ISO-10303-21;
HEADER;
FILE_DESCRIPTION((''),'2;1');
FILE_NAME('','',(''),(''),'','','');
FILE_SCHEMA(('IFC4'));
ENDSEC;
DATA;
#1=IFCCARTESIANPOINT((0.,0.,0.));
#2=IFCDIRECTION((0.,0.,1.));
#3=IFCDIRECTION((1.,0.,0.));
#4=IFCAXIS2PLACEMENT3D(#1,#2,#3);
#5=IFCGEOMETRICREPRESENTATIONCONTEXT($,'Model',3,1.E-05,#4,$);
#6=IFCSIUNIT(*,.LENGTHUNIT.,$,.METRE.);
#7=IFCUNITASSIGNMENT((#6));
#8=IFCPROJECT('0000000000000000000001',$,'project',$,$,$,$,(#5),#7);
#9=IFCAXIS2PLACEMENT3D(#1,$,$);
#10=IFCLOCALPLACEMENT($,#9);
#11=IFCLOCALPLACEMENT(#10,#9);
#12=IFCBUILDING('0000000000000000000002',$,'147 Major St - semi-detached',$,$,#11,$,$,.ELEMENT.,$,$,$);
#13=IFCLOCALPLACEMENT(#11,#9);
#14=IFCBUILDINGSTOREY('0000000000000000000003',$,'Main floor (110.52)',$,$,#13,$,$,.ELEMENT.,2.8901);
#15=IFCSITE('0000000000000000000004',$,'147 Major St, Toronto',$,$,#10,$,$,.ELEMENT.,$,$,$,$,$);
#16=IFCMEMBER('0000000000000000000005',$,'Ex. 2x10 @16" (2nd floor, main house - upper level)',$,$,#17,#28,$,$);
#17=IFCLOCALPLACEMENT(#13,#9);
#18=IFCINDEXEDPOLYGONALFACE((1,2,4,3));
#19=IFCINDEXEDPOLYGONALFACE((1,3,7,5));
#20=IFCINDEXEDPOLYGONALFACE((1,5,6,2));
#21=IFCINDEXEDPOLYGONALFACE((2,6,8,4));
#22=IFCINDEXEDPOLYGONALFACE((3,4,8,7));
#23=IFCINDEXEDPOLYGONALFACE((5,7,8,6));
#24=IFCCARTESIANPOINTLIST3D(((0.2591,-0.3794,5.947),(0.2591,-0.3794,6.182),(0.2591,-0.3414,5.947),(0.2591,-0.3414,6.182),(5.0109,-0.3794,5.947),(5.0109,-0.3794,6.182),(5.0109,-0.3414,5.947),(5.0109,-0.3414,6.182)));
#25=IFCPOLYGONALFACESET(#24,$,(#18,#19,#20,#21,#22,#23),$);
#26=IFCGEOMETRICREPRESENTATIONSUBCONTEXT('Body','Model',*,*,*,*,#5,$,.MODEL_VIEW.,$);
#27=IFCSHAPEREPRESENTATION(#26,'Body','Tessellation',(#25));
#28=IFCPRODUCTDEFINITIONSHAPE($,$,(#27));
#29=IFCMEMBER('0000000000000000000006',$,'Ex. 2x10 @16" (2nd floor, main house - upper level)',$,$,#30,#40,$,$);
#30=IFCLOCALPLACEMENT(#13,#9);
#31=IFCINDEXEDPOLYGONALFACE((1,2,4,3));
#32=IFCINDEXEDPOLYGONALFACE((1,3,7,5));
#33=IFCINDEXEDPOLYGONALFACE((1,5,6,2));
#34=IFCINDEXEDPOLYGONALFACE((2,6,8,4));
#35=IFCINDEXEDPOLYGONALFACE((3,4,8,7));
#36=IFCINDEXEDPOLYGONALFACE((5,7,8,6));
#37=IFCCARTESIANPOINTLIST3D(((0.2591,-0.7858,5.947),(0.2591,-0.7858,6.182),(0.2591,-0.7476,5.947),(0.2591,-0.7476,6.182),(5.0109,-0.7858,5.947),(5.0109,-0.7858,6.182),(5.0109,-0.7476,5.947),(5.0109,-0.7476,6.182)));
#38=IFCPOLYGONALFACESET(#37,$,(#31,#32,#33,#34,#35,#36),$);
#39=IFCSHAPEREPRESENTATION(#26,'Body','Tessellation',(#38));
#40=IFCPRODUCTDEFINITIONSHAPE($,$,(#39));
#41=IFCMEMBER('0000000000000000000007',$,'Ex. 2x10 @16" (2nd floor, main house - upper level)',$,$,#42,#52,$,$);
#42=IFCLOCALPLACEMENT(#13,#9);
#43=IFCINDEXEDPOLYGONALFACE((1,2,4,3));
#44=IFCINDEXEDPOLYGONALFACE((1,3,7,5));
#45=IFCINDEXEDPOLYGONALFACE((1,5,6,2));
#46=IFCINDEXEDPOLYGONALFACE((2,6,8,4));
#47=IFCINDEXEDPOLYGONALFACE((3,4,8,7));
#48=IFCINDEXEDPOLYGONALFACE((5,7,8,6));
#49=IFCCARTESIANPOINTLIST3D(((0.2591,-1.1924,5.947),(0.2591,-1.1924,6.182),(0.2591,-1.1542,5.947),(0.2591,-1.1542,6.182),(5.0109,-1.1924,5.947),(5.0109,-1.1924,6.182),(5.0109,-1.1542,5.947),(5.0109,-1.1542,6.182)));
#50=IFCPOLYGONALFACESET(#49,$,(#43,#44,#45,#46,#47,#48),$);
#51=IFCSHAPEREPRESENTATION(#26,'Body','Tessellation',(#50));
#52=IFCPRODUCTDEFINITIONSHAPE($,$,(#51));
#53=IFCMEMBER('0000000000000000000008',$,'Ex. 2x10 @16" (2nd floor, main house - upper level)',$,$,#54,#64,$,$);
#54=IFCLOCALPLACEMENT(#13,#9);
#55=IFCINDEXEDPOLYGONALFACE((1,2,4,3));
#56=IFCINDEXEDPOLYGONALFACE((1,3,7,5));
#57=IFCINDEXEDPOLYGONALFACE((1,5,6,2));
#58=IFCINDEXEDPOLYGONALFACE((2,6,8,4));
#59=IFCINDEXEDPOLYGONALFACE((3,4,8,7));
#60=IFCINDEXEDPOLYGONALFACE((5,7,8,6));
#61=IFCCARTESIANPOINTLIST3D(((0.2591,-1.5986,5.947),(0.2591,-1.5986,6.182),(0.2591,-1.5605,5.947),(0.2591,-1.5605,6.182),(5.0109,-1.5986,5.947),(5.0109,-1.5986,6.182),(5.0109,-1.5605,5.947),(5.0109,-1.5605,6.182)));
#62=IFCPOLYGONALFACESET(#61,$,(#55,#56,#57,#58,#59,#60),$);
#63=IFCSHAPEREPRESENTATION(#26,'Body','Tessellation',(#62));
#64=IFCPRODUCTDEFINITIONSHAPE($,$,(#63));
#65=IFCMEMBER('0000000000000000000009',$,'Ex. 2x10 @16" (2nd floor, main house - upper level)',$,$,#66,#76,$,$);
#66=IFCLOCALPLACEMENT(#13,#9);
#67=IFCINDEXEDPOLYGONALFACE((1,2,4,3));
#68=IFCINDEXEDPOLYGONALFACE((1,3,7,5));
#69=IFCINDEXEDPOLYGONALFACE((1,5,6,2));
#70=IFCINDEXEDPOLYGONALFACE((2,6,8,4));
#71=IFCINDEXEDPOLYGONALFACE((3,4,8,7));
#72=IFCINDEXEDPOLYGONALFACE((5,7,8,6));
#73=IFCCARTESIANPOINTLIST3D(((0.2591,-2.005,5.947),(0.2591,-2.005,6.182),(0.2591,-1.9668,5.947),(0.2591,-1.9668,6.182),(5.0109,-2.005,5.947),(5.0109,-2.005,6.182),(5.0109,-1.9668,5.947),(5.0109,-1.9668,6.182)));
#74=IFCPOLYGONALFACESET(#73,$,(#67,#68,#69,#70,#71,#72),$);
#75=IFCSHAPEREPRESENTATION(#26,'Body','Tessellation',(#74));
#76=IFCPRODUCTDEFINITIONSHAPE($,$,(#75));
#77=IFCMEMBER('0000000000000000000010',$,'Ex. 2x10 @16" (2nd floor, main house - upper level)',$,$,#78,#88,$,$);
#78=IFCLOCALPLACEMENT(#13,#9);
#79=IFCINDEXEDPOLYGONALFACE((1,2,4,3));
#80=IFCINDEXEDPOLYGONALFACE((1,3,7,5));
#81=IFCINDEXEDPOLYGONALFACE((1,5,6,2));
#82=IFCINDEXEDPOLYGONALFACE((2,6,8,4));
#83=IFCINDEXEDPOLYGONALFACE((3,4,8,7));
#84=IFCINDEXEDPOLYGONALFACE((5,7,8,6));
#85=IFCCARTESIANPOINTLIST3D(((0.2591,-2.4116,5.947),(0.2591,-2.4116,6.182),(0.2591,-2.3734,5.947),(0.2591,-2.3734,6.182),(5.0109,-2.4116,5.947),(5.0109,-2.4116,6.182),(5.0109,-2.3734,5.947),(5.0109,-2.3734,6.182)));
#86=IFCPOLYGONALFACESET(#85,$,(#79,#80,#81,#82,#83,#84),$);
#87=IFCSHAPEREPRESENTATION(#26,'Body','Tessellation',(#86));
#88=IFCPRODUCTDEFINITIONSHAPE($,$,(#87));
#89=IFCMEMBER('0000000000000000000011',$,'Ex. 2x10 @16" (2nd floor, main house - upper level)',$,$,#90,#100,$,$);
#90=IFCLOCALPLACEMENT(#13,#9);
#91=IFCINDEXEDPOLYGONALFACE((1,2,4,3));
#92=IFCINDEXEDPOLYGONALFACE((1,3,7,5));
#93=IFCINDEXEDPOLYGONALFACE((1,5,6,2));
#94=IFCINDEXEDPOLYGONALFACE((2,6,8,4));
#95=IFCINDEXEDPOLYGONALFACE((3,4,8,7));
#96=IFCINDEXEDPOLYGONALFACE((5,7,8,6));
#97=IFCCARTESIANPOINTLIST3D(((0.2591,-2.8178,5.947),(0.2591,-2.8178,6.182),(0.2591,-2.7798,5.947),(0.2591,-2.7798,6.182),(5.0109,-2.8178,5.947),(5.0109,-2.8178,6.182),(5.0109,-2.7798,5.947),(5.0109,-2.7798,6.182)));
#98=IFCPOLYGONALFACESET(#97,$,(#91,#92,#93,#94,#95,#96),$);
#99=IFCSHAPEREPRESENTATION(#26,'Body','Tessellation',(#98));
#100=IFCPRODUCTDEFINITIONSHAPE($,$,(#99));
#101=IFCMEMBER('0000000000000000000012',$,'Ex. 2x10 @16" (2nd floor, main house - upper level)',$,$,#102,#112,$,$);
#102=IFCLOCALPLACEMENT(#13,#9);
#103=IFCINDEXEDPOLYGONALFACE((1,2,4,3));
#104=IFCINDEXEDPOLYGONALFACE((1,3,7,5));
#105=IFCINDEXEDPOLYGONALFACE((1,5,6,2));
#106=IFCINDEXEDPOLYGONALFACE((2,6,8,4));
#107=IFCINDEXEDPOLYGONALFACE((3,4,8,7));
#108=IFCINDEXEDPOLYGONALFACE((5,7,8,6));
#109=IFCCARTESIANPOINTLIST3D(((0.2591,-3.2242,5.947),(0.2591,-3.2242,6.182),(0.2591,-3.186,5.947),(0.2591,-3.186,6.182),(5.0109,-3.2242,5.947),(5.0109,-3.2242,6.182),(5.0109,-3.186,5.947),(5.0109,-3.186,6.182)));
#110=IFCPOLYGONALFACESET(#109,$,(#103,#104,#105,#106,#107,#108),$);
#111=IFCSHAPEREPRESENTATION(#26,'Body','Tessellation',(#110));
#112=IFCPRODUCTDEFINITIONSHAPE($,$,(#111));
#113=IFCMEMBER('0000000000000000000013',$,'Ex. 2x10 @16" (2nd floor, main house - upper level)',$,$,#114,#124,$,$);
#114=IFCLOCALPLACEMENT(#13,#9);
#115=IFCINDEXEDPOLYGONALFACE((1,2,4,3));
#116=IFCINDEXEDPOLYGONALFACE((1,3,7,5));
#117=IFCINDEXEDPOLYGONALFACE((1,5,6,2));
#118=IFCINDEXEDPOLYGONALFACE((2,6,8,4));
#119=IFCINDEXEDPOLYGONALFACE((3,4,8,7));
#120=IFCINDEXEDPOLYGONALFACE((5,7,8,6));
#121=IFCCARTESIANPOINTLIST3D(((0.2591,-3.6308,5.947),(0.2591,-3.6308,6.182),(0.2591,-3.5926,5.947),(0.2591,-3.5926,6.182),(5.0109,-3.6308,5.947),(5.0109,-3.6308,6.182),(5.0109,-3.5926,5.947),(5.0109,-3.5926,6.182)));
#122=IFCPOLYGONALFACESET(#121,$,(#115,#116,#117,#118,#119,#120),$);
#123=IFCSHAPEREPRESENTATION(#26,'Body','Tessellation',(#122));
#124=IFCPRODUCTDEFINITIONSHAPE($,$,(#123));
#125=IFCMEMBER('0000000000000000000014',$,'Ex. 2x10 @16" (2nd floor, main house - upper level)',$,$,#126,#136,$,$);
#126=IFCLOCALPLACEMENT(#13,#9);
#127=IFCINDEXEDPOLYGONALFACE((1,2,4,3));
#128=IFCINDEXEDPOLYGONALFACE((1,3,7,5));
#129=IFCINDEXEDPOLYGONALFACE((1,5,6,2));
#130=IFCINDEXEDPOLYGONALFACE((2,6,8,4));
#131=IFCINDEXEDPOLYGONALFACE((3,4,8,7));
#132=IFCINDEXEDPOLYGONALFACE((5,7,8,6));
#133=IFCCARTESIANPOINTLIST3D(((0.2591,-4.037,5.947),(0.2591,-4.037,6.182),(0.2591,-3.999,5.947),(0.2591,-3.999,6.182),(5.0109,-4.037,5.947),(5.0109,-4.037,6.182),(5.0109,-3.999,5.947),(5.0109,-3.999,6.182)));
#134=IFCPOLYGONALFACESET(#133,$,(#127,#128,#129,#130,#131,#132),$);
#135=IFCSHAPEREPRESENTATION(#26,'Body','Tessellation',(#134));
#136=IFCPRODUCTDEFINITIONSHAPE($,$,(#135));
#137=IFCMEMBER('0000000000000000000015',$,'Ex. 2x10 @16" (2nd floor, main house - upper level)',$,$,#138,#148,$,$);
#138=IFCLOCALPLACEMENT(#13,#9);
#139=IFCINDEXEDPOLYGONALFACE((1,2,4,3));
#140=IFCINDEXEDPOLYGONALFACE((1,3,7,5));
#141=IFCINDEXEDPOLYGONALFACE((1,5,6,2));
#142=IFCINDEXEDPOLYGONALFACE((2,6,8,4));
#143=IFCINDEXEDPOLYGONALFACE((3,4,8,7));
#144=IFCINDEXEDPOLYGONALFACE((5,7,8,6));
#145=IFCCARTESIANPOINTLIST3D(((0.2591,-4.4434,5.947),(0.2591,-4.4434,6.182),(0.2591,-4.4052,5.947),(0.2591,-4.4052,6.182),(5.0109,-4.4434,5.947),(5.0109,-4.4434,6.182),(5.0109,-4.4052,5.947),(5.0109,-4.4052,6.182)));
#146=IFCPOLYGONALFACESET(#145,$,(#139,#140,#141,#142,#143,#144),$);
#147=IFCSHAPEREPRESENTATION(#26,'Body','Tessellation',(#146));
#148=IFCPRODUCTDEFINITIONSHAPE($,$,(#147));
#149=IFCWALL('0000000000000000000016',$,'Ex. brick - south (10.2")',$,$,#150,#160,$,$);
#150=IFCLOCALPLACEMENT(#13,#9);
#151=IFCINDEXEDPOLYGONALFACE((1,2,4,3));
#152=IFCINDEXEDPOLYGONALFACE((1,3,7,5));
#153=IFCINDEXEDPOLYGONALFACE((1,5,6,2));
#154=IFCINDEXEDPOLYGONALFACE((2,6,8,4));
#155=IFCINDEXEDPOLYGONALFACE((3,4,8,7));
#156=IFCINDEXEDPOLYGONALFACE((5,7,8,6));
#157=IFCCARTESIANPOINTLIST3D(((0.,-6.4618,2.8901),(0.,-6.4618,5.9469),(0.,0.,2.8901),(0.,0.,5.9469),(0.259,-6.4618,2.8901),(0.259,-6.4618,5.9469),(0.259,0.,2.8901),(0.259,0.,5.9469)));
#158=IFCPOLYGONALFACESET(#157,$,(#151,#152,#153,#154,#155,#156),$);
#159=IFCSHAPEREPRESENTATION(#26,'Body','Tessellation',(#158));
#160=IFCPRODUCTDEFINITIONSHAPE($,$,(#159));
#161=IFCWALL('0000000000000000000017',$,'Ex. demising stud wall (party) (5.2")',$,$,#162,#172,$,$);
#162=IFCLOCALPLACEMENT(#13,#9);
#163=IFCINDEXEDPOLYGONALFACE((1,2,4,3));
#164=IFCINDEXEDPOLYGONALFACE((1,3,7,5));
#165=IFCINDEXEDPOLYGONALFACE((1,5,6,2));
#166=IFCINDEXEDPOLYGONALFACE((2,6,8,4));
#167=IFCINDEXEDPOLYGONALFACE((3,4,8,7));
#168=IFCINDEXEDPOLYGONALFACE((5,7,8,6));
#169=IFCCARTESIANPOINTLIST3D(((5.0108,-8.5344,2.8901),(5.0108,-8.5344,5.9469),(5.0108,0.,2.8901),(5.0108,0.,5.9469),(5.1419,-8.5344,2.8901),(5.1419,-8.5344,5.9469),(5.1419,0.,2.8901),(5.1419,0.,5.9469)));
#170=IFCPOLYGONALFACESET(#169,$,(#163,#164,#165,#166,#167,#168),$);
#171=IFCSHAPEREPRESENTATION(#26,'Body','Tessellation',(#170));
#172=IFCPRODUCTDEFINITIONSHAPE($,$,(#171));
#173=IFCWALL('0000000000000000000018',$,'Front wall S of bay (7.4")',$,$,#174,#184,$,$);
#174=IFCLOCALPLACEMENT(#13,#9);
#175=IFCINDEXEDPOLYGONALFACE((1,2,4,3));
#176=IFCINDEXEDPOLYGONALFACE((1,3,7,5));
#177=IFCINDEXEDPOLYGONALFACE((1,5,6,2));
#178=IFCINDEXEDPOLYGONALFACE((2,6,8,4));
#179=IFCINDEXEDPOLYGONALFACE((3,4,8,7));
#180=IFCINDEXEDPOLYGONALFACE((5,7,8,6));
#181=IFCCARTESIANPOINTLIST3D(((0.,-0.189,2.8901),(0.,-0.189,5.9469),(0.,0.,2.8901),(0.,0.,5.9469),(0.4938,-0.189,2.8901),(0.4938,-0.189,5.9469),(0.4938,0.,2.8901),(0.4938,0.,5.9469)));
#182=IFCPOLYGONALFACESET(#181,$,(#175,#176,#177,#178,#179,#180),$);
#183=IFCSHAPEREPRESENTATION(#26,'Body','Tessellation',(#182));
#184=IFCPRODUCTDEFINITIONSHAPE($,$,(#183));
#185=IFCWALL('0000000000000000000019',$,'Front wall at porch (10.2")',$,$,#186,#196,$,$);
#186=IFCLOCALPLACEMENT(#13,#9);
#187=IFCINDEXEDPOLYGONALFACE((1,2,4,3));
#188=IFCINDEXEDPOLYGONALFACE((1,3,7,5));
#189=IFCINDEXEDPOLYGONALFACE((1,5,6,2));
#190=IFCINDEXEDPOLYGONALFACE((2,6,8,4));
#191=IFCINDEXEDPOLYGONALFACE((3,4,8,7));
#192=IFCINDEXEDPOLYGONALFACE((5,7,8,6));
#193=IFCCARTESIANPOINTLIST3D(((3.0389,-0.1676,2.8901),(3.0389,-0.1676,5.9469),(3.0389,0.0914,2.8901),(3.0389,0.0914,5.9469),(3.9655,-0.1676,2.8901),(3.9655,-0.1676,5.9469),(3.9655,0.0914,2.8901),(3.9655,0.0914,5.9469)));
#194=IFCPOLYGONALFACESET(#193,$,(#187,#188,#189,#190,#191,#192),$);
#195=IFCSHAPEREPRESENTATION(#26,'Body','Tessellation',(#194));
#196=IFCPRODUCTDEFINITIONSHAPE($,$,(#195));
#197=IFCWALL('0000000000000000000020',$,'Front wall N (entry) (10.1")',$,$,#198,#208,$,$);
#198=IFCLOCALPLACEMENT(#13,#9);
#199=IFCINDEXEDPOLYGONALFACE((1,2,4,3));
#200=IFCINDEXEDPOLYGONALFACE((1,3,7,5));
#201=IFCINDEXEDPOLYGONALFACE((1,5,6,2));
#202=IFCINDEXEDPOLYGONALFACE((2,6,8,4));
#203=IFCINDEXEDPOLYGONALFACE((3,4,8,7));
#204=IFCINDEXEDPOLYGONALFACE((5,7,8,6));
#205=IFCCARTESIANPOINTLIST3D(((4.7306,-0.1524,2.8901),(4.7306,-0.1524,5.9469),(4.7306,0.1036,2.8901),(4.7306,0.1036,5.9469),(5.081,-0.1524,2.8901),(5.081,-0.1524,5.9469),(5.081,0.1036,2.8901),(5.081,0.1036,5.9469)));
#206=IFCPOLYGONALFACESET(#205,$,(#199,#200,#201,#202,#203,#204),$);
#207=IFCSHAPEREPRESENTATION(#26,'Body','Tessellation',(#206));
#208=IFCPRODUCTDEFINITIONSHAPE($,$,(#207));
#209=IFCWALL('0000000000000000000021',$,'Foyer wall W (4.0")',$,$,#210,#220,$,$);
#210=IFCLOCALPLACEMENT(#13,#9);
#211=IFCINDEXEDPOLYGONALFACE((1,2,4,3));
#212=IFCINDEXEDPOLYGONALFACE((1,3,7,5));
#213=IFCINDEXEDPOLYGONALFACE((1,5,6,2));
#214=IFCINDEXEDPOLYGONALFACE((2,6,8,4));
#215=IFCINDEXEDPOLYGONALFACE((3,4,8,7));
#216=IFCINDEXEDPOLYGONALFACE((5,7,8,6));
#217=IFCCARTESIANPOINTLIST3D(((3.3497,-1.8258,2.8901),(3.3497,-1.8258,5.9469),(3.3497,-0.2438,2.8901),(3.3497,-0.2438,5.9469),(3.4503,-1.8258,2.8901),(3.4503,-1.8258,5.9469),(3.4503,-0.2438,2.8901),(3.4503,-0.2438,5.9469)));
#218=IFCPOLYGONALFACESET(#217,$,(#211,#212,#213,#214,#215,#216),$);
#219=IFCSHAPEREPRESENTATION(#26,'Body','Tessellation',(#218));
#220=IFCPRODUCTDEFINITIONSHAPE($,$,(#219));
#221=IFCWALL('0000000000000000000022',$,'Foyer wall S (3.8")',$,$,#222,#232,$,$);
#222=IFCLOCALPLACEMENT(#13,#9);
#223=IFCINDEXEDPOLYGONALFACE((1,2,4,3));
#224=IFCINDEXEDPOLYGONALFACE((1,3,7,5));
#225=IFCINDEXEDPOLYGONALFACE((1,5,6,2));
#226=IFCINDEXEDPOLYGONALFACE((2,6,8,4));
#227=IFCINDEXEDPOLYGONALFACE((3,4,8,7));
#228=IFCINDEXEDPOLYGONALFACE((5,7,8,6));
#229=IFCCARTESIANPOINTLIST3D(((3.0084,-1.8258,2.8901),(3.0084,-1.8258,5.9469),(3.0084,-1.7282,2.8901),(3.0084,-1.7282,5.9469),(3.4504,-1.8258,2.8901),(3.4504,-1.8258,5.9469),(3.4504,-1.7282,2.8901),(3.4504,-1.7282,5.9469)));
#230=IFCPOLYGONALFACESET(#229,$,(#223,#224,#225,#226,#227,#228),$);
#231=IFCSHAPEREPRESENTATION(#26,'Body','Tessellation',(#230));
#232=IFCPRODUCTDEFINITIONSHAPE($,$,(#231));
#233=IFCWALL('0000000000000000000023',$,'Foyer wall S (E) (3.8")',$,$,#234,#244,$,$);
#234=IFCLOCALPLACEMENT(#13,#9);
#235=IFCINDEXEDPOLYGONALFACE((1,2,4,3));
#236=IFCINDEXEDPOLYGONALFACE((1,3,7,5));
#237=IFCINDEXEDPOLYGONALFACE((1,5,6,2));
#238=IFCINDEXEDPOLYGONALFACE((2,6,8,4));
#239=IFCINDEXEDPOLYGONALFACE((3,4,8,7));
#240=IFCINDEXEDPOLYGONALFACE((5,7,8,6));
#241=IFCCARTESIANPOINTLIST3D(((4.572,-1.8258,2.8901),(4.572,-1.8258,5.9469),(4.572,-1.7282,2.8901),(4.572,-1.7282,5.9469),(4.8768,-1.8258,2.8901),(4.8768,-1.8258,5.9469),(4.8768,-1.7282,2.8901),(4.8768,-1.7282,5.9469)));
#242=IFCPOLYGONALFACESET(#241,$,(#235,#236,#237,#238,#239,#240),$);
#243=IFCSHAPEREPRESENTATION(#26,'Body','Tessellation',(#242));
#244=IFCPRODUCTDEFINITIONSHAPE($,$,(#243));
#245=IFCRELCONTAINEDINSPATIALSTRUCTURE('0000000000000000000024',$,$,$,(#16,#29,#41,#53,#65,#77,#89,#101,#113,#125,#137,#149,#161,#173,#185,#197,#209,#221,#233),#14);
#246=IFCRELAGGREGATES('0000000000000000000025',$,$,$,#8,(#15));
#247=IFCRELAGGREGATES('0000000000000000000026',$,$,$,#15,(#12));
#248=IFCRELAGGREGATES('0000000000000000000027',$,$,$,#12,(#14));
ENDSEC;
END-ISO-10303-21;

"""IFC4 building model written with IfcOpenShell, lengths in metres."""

from ifc_helpers import new_model, si_unit, frame, origin, origin_with_axes, place, context, subcontext, project, spatial, rectangle, extrude, element, save


model = new_model("IFC4")

# Units and contexts
model_context = context("Model", 3, precision=1e-05, world=origin_with_axes())
body_context = subcontext(model_context, "Body", "Model", "MODEL_VIEW")
ifc_project = project(units=[si_unit("LENGTHUNIT", "METRE")], contexts=[model_context])

# Site, building, storey
site_placement = place(None, origin())
site = spatial("IfcSite", under=ifc_project, at=site_placement, Name="147 Major St, Toronto", CompositionType="ELEMENT")
building_placement = place(site_placement, origin())
building = spatial("IfcBuilding", under=site, at=building_placement, Name="147 Major St - semi-detached", CompositionType="ELEMENT")
storey_placement = place(building_placement, origin())
storey = spatial("IfcBuildingStorey", under=building, at=storey_placement, Name="Main floor (110.52)", CompositionType="ELEMENT", Elevation=2.8901)

# Members
for number, where, name in (
    (1, (2.635, -0.3604, 5.947), "Ex. 2x10 @16\" (2nd floor, main house - upper level)"),
    (2, (2.635, -0.7667, 5.947), "Ex. 2x10 @16\" (2nd floor, main house - upper level)"),
    (3, (2.635, -1.1733, 5.947), "Ex. 2x10 @16\" (2nd floor, main house - upper level)"),
    (4, (2.635, -1.5796, 5.947), "Ex. 2x10 @16\" (2nd floor, main house - upper level)"),
    (5, (2.635, -1.9859, 5.947), "Ex. 2x10 @16\" (2nd floor, main house - upper level)"),
    (6, (2.635, -2.3925, 5.947), "Ex. 2x10 @16\" (2nd floor, main house - upper level)"),
    (7, (2.635, -2.7988, 5.947), "Ex. 2x10 @16\" (2nd floor, main house - upper level)"),
    (8, (2.635, -3.2051, 5.947), "Ex. 2x10 @16\" (2nd floor, main house - upper level)"),
    (9, (2.635, -3.6117, 5.947), "Ex. 2x10 @16\" (2nd floor, main house - upper level)"),
    (10, (2.635, -4.018, 5.947), "Ex. 2x10 @16\" (2nd floor, main house - upper level)"),
    (11, (2.635, -4.4243, 5.947), "Ex. 2x10 @16\" (2nd floor, main house - upper level)"),
):
    element("IfcMember", number, at=place(storey_placement, frame(where)), inside=storey, Name=name, context=body_context, shape_type="SweptSolid", body=[
        extrude(rectangle(XDim=4.7518, YDim=0.0381), origin_with_axes(), (0.0, 0.0, 1.0), 0.235),
    ])

# Walls
wall_1_placement = place(storey_placement, frame((0.1295, -3.2309, 2.8901)))
element("IfcWall", 12, at=wall_1_placement, inside=storey, Name="Ex. brick - south (10.2\")", context=body_context, shape_type="SweptSolid", body=[
    extrude(rectangle(XDim=0.2591, YDim=6.4618), origin_with_axes(), (0.0, 0.0, 1.0), 3.0568),
])
wall_2_placement = place(storey_placement, frame((5.0764, -4.2672, 2.8901)))
element("IfcWall", 13, at=wall_2_placement, inside=storey, Name="Ex. demising stud wall (party) (5.2\")", context=body_context, shape_type="SweptSolid", body=[
    extrude(rectangle(XDim=0.1311, YDim=8.5344), origin_with_axes(), (0.0, 0.0, 1.0), 3.0568),
])
wall_3_placement = place(storey_placement, frame((0.2469, -0.0945, 2.8901)))
element("IfcWall", 14, at=wall_3_placement, inside=storey, Name="Front wall S of bay (7.4\")", context=body_context, shape_type="SweptSolid", body=[
    extrude(rectangle(XDim=0.4938, YDim=0.189), origin_with_axes(), (0.0, 0.0, 1.0), 3.0568),
])
wall_4_placement = place(storey_placement, frame((3.5022, -0.0381, 2.8901)))
element("IfcWall", 15, at=wall_4_placement, inside=storey, Name="Front wall at porch (10.2\")", context=body_context, shape_type="SweptSolid", body=[
    extrude(rectangle(XDim=0.9266, YDim=0.2591), origin_with_axes(), (0.0, 0.0, 1.0), 3.0568),
])
wall_5_placement = place(storey_placement, frame((4.9058, -0.0244, 2.8901)))
element("IfcWall", 16, at=wall_5_placement, inside=storey, Name="Front wall N (entry) (10.1\")", context=body_context, shape_type="SweptSolid", body=[
    extrude(rectangle(XDim=0.3505, YDim=0.256), origin_with_axes(), (0.0, 0.0, 1.0), 3.0568),
])
wall_6_placement = place(storey_placement, frame((3.4, -1.0348, 2.8901)))
element("IfcWall", 17, at=wall_6_placement, inside=storey, Name="Foyer wall W (4.0\")", context=body_context, shape_type="SweptSolid", body=[
    extrude(rectangle(XDim=0.1006, YDim=1.5819), origin_with_axes(), (0.0, 0.0, 1.0), 3.0568),
])
wall_7_placement = place(storey_placement, frame((3.2294, -1.777, 2.8901)))
element("IfcWall", 18, at=wall_7_placement, inside=storey, Name="Foyer wall S (3.8\")", context=body_context, shape_type="SweptSolid", body=[
    extrude(rectangle(XDim=0.442, YDim=0.0975), origin_with_axes(), (0.0, 0.0, 1.0), 3.0568),
])
wall_8_placement = place(storey_placement, frame((4.7244, -1.777, 2.8901)))
element("IfcWall", 19, at=wall_8_placement, inside=storey, Name="Foyer wall S (E) (3.8\")", context=body_context, shape_type="SweptSolid", body=[
    extrude(rectangle(XDim=0.3048, YDim=0.0975), origin_with_axes(), (0.0, 0.0, 1.0), 3.0568),
])

save(model, "model.ifc")
